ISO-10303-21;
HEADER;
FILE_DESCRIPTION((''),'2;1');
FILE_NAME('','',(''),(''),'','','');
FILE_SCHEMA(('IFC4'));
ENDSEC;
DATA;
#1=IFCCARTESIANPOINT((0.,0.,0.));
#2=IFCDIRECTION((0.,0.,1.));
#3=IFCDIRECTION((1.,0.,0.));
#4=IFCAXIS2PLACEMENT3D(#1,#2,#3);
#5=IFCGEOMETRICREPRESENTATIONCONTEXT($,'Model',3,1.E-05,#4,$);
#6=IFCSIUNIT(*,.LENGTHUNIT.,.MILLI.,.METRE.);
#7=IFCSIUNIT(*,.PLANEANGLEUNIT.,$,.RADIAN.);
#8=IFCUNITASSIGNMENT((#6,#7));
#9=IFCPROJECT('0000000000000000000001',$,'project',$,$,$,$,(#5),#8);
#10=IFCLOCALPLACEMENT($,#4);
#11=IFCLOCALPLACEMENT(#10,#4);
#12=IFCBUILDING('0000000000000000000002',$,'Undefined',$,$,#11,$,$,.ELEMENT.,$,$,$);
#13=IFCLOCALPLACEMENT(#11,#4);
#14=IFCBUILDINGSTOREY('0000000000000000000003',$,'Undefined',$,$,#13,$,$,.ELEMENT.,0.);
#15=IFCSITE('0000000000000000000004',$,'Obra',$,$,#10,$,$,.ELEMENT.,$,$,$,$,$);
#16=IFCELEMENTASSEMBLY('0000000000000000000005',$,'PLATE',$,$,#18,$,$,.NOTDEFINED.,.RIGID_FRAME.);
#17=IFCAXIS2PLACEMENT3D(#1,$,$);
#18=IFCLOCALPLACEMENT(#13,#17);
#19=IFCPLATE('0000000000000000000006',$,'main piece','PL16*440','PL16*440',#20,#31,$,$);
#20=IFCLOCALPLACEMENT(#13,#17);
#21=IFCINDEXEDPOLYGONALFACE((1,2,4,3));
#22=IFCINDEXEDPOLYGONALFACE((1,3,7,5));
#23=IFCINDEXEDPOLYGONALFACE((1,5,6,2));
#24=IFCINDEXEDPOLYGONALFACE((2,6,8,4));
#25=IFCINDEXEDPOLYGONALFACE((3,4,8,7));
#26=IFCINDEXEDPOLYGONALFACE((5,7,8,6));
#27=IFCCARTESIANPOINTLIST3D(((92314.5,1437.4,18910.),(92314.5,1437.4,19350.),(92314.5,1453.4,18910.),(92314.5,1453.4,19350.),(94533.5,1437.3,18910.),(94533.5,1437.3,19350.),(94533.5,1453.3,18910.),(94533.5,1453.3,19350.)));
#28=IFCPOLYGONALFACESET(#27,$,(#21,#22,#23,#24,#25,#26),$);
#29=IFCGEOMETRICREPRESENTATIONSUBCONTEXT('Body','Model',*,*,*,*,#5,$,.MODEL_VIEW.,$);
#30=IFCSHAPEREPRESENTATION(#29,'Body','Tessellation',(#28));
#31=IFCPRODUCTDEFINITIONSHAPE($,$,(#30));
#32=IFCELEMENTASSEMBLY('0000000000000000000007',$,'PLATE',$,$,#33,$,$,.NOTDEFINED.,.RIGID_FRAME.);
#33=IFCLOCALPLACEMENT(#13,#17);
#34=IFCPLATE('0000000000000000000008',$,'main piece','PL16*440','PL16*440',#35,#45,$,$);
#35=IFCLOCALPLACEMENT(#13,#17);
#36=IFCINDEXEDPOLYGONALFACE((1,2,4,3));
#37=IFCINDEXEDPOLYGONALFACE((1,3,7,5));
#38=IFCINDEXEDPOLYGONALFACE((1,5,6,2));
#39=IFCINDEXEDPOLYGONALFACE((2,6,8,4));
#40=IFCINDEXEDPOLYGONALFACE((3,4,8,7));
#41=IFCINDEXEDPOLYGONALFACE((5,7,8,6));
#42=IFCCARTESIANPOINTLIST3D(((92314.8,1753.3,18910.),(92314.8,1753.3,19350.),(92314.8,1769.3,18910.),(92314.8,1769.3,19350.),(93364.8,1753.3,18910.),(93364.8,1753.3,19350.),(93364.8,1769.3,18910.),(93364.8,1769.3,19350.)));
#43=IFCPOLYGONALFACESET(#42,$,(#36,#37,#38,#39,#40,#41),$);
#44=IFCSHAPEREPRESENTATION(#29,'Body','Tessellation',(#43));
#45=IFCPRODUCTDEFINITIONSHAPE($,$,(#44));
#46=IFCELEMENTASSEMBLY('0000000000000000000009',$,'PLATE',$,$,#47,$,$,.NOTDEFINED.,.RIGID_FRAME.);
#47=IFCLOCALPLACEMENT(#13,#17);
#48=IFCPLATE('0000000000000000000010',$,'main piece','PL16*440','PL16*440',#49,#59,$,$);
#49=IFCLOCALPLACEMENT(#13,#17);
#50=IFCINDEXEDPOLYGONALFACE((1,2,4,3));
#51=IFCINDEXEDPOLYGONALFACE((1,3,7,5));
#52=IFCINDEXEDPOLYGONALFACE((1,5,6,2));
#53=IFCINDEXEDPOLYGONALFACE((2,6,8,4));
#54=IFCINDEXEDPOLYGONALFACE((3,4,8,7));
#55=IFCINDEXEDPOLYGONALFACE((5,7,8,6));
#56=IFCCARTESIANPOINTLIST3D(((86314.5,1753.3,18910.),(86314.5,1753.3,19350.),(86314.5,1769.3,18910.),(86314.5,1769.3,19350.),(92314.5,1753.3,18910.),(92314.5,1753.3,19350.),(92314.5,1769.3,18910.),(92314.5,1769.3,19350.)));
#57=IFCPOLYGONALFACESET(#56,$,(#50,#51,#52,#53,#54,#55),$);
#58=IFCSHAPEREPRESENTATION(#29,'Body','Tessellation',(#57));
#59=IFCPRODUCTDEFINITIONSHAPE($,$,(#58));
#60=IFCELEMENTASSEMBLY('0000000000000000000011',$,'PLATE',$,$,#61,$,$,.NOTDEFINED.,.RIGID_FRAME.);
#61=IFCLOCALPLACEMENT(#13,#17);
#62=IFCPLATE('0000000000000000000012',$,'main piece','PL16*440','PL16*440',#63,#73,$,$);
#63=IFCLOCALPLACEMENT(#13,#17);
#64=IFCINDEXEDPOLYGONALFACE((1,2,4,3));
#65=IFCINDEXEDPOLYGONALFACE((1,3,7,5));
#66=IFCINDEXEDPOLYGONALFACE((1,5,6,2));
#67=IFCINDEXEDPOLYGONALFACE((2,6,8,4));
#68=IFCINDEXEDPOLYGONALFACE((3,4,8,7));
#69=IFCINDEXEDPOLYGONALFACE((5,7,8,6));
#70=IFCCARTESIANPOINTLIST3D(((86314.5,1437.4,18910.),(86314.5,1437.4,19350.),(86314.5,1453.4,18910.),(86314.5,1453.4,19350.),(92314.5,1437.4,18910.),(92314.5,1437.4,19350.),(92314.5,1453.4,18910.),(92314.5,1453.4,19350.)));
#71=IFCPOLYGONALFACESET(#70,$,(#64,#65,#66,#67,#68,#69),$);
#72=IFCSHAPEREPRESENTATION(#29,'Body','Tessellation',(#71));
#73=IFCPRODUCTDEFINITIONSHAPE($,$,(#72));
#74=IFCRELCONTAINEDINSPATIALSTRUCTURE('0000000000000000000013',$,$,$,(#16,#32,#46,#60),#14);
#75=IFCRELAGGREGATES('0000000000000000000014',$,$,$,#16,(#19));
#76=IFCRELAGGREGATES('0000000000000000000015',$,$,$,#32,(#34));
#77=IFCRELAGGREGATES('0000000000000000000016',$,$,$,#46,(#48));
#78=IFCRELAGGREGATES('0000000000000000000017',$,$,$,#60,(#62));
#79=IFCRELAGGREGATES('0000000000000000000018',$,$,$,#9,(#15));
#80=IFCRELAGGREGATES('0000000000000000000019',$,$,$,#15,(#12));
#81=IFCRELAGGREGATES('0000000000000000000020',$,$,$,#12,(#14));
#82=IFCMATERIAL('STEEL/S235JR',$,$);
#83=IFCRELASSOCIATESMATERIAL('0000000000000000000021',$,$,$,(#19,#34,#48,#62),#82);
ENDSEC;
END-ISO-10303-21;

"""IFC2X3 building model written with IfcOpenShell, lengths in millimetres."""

from ifc_helpers import new_model, si_unit, frame, origin_with_axes, place, context, subcontext, project, spatial, polyline, outline, extrude, material, element, aggregate, save


model = new_model("IFC2X3")

# Units and contexts
model_context = context("Model", 3, precision=1e-05, world=origin_with_axes())
body_context = subcontext(model_context, "Body", "Model", "MODEL_VIEW")
ifc_project = project(units=[si_unit("LENGTHUNIT", "METRE", prefix="MILLI"), si_unit("PLANEANGLEUNIT", "RADIAN")], contexts=[model_context])

# Site, building, storey
site_placement = place(None, origin_with_axes())
site = spatial("IfcSite", under=ifc_project, at=site_placement, Name="Obra", CompositionType="ELEMENT")
building_placement = place(site_placement, origin_with_axes())
building = spatial("IfcBuilding", under=site, at=building_placement, Name="Undefined", CompositionType="ELEMENT")
storey_placement = place(building_placement, origin_with_axes())
storey = spatial("IfcBuildingStorey", under=building, at=storey_placement, Name="Undefined", CompositionType="ELEMENT", Elevation=0.0)

# Shared definitions
ifc_material_1 = material(Name="STEEL/S235JR")

# Element assemblies, plates
assembly_1_placement = place(storey_placement, origin_with_axes())
assembly_1 = element("IfcElementAssembly", 1, at=assembly_1_placement, inside=storey, Name="PLATE", AssemblyPlace="NOTDEFINED", PredefinedType="RIGID_FRAME")
plate_1_placement = place(assembly_1_placement, frame((92314.5, 1445.4, 19350.0), z_axis=(-0.000053, -1.0, 0.0), x_axis=(0.0, 0.0, -1.0)))
plate_1 = element("IfcPlate", 2, at=plate_1_placement, material=ifc_material_1, Name="main piece", Description="PL16*440", ObjectType="PL16*440", context=body_context, shape_type="SweptSolid", body=[
    extrude(outline(polyline([(0.0, 0.0), (440.0, 0.0), (440.0, 2219.0), (0.0, 2219.0), (0.0, 0.0)])), frame((0.0, 0.0, -8.0), z_axis=(0.0, 0.0, 1.0), x_axis=(1.0, 0.0, 0.0)), (0.0, 0.0, 1.0), 16.0),
])
aggregate(assembly_1, [plate_1])
assembly_2_placement = place(storey_placement, origin_with_axes())
assembly_2 = element("IfcElementAssembly", 3, at=assembly_2_placement, inside=storey, Name="PLATE", AssemblyPlace="NOTDEFINED", PredefinedType="RIGID_FRAME")
plate_2_placement = place(assembly_2_placement, frame((92314.8, 1761.3, 19350.0), z_axis=(0.0, -1.0, 0.0), x_axis=(0.0, 0.0, -1.0)))
plate_2 = element("IfcPlate", 4, at=plate_2_placement, material=ifc_material_1, Name="main piece", Description="PL16*440", ObjectType="PL16*440", context=body_context, shape_type="SweptSolid", body=[
    extrude(outline(polyline([(0.0, 0.0), (440.0, 0.0), (440.0, 1050.0), (0.0, 1050.0), (0.0, 0.0)])), frame((0.0, 0.0, -8.0), z_axis=(0.0, 0.0, 1.0), x_axis=(1.0, 0.0, 0.0)), (0.0, 0.0, 1.0), 16.0),
])
aggregate(assembly_2, [plate_2])
assembly_3_placement = place(storey_placement, origin_with_axes())
assembly_3 = element("IfcElementAssembly", 5, at=assembly_3_placement, inside=storey, Name="PLATE", AssemblyPlace="NOTDEFINED", PredefinedType="RIGID_FRAME")
plate_3_placement = place(assembly_3_placement, frame((86314.5, 1761.3, 19350.0), z_axis=(0.0, -1.0, 0.0), x_axis=(0.0, 0.0, -1.0)))
plate_3 = element("IfcPlate", 6, at=plate_3_placement, material=ifc_material_1, Name="main piece", Description="PL16*440", ObjectType="PL16*440", context=body_context, shape_type="SweptSolid", body=[
    extrude(outline(polyline([(0.0, 0.0), (440.0, 0.0), (440.0, 6000.0), (0.0, 6000.0), (0.0, 0.0)])), frame((0.0, 0.0, -8.0), z_axis=(0.0, 0.0, 1.0), x_axis=(1.0, 0.0, 0.0)), (0.0, 0.0, 1.0), 16.0),
])
aggregate(assembly_3, [plate_3])
assembly_4_placement = place(storey_placement, origin_with_axes())
assembly_4 = element("IfcElementAssembly", 7, at=assembly_4_placement, inside=storey, Name="PLATE", AssemblyPlace="NOTDEFINED", PredefinedType="RIGID_FRAME")
plate_4_placement = place(assembly_4_placement, frame((86314.5, 1445.4, 19350.0), z_axis=(0.0, -1.0, 0.0), x_axis=(0.0, 0.0, -1.0)))
plate_4 = element("IfcPlate", 8, at=plate_4_placement, material=ifc_material_1, Name="main piece", Description="PL16*440", ObjectType="PL16*440", context=body_context, shape_type="SweptSolid", body=[
    extrude(outline(polyline([(0.0, 0.0), (440.0, 0.0), (440.0, 6000.0), (0.0, 6000.0), (0.0, 0.0)])), frame((0.0, 0.0, -8.0), z_axis=(0.0, 0.0, 1.0), x_axis=(1.0, 0.0, 0.0)), (0.0, 0.0, 1.0), 16.0),
])
aggregate(assembly_4, [plate_4])

save(model, "model.ifc")
